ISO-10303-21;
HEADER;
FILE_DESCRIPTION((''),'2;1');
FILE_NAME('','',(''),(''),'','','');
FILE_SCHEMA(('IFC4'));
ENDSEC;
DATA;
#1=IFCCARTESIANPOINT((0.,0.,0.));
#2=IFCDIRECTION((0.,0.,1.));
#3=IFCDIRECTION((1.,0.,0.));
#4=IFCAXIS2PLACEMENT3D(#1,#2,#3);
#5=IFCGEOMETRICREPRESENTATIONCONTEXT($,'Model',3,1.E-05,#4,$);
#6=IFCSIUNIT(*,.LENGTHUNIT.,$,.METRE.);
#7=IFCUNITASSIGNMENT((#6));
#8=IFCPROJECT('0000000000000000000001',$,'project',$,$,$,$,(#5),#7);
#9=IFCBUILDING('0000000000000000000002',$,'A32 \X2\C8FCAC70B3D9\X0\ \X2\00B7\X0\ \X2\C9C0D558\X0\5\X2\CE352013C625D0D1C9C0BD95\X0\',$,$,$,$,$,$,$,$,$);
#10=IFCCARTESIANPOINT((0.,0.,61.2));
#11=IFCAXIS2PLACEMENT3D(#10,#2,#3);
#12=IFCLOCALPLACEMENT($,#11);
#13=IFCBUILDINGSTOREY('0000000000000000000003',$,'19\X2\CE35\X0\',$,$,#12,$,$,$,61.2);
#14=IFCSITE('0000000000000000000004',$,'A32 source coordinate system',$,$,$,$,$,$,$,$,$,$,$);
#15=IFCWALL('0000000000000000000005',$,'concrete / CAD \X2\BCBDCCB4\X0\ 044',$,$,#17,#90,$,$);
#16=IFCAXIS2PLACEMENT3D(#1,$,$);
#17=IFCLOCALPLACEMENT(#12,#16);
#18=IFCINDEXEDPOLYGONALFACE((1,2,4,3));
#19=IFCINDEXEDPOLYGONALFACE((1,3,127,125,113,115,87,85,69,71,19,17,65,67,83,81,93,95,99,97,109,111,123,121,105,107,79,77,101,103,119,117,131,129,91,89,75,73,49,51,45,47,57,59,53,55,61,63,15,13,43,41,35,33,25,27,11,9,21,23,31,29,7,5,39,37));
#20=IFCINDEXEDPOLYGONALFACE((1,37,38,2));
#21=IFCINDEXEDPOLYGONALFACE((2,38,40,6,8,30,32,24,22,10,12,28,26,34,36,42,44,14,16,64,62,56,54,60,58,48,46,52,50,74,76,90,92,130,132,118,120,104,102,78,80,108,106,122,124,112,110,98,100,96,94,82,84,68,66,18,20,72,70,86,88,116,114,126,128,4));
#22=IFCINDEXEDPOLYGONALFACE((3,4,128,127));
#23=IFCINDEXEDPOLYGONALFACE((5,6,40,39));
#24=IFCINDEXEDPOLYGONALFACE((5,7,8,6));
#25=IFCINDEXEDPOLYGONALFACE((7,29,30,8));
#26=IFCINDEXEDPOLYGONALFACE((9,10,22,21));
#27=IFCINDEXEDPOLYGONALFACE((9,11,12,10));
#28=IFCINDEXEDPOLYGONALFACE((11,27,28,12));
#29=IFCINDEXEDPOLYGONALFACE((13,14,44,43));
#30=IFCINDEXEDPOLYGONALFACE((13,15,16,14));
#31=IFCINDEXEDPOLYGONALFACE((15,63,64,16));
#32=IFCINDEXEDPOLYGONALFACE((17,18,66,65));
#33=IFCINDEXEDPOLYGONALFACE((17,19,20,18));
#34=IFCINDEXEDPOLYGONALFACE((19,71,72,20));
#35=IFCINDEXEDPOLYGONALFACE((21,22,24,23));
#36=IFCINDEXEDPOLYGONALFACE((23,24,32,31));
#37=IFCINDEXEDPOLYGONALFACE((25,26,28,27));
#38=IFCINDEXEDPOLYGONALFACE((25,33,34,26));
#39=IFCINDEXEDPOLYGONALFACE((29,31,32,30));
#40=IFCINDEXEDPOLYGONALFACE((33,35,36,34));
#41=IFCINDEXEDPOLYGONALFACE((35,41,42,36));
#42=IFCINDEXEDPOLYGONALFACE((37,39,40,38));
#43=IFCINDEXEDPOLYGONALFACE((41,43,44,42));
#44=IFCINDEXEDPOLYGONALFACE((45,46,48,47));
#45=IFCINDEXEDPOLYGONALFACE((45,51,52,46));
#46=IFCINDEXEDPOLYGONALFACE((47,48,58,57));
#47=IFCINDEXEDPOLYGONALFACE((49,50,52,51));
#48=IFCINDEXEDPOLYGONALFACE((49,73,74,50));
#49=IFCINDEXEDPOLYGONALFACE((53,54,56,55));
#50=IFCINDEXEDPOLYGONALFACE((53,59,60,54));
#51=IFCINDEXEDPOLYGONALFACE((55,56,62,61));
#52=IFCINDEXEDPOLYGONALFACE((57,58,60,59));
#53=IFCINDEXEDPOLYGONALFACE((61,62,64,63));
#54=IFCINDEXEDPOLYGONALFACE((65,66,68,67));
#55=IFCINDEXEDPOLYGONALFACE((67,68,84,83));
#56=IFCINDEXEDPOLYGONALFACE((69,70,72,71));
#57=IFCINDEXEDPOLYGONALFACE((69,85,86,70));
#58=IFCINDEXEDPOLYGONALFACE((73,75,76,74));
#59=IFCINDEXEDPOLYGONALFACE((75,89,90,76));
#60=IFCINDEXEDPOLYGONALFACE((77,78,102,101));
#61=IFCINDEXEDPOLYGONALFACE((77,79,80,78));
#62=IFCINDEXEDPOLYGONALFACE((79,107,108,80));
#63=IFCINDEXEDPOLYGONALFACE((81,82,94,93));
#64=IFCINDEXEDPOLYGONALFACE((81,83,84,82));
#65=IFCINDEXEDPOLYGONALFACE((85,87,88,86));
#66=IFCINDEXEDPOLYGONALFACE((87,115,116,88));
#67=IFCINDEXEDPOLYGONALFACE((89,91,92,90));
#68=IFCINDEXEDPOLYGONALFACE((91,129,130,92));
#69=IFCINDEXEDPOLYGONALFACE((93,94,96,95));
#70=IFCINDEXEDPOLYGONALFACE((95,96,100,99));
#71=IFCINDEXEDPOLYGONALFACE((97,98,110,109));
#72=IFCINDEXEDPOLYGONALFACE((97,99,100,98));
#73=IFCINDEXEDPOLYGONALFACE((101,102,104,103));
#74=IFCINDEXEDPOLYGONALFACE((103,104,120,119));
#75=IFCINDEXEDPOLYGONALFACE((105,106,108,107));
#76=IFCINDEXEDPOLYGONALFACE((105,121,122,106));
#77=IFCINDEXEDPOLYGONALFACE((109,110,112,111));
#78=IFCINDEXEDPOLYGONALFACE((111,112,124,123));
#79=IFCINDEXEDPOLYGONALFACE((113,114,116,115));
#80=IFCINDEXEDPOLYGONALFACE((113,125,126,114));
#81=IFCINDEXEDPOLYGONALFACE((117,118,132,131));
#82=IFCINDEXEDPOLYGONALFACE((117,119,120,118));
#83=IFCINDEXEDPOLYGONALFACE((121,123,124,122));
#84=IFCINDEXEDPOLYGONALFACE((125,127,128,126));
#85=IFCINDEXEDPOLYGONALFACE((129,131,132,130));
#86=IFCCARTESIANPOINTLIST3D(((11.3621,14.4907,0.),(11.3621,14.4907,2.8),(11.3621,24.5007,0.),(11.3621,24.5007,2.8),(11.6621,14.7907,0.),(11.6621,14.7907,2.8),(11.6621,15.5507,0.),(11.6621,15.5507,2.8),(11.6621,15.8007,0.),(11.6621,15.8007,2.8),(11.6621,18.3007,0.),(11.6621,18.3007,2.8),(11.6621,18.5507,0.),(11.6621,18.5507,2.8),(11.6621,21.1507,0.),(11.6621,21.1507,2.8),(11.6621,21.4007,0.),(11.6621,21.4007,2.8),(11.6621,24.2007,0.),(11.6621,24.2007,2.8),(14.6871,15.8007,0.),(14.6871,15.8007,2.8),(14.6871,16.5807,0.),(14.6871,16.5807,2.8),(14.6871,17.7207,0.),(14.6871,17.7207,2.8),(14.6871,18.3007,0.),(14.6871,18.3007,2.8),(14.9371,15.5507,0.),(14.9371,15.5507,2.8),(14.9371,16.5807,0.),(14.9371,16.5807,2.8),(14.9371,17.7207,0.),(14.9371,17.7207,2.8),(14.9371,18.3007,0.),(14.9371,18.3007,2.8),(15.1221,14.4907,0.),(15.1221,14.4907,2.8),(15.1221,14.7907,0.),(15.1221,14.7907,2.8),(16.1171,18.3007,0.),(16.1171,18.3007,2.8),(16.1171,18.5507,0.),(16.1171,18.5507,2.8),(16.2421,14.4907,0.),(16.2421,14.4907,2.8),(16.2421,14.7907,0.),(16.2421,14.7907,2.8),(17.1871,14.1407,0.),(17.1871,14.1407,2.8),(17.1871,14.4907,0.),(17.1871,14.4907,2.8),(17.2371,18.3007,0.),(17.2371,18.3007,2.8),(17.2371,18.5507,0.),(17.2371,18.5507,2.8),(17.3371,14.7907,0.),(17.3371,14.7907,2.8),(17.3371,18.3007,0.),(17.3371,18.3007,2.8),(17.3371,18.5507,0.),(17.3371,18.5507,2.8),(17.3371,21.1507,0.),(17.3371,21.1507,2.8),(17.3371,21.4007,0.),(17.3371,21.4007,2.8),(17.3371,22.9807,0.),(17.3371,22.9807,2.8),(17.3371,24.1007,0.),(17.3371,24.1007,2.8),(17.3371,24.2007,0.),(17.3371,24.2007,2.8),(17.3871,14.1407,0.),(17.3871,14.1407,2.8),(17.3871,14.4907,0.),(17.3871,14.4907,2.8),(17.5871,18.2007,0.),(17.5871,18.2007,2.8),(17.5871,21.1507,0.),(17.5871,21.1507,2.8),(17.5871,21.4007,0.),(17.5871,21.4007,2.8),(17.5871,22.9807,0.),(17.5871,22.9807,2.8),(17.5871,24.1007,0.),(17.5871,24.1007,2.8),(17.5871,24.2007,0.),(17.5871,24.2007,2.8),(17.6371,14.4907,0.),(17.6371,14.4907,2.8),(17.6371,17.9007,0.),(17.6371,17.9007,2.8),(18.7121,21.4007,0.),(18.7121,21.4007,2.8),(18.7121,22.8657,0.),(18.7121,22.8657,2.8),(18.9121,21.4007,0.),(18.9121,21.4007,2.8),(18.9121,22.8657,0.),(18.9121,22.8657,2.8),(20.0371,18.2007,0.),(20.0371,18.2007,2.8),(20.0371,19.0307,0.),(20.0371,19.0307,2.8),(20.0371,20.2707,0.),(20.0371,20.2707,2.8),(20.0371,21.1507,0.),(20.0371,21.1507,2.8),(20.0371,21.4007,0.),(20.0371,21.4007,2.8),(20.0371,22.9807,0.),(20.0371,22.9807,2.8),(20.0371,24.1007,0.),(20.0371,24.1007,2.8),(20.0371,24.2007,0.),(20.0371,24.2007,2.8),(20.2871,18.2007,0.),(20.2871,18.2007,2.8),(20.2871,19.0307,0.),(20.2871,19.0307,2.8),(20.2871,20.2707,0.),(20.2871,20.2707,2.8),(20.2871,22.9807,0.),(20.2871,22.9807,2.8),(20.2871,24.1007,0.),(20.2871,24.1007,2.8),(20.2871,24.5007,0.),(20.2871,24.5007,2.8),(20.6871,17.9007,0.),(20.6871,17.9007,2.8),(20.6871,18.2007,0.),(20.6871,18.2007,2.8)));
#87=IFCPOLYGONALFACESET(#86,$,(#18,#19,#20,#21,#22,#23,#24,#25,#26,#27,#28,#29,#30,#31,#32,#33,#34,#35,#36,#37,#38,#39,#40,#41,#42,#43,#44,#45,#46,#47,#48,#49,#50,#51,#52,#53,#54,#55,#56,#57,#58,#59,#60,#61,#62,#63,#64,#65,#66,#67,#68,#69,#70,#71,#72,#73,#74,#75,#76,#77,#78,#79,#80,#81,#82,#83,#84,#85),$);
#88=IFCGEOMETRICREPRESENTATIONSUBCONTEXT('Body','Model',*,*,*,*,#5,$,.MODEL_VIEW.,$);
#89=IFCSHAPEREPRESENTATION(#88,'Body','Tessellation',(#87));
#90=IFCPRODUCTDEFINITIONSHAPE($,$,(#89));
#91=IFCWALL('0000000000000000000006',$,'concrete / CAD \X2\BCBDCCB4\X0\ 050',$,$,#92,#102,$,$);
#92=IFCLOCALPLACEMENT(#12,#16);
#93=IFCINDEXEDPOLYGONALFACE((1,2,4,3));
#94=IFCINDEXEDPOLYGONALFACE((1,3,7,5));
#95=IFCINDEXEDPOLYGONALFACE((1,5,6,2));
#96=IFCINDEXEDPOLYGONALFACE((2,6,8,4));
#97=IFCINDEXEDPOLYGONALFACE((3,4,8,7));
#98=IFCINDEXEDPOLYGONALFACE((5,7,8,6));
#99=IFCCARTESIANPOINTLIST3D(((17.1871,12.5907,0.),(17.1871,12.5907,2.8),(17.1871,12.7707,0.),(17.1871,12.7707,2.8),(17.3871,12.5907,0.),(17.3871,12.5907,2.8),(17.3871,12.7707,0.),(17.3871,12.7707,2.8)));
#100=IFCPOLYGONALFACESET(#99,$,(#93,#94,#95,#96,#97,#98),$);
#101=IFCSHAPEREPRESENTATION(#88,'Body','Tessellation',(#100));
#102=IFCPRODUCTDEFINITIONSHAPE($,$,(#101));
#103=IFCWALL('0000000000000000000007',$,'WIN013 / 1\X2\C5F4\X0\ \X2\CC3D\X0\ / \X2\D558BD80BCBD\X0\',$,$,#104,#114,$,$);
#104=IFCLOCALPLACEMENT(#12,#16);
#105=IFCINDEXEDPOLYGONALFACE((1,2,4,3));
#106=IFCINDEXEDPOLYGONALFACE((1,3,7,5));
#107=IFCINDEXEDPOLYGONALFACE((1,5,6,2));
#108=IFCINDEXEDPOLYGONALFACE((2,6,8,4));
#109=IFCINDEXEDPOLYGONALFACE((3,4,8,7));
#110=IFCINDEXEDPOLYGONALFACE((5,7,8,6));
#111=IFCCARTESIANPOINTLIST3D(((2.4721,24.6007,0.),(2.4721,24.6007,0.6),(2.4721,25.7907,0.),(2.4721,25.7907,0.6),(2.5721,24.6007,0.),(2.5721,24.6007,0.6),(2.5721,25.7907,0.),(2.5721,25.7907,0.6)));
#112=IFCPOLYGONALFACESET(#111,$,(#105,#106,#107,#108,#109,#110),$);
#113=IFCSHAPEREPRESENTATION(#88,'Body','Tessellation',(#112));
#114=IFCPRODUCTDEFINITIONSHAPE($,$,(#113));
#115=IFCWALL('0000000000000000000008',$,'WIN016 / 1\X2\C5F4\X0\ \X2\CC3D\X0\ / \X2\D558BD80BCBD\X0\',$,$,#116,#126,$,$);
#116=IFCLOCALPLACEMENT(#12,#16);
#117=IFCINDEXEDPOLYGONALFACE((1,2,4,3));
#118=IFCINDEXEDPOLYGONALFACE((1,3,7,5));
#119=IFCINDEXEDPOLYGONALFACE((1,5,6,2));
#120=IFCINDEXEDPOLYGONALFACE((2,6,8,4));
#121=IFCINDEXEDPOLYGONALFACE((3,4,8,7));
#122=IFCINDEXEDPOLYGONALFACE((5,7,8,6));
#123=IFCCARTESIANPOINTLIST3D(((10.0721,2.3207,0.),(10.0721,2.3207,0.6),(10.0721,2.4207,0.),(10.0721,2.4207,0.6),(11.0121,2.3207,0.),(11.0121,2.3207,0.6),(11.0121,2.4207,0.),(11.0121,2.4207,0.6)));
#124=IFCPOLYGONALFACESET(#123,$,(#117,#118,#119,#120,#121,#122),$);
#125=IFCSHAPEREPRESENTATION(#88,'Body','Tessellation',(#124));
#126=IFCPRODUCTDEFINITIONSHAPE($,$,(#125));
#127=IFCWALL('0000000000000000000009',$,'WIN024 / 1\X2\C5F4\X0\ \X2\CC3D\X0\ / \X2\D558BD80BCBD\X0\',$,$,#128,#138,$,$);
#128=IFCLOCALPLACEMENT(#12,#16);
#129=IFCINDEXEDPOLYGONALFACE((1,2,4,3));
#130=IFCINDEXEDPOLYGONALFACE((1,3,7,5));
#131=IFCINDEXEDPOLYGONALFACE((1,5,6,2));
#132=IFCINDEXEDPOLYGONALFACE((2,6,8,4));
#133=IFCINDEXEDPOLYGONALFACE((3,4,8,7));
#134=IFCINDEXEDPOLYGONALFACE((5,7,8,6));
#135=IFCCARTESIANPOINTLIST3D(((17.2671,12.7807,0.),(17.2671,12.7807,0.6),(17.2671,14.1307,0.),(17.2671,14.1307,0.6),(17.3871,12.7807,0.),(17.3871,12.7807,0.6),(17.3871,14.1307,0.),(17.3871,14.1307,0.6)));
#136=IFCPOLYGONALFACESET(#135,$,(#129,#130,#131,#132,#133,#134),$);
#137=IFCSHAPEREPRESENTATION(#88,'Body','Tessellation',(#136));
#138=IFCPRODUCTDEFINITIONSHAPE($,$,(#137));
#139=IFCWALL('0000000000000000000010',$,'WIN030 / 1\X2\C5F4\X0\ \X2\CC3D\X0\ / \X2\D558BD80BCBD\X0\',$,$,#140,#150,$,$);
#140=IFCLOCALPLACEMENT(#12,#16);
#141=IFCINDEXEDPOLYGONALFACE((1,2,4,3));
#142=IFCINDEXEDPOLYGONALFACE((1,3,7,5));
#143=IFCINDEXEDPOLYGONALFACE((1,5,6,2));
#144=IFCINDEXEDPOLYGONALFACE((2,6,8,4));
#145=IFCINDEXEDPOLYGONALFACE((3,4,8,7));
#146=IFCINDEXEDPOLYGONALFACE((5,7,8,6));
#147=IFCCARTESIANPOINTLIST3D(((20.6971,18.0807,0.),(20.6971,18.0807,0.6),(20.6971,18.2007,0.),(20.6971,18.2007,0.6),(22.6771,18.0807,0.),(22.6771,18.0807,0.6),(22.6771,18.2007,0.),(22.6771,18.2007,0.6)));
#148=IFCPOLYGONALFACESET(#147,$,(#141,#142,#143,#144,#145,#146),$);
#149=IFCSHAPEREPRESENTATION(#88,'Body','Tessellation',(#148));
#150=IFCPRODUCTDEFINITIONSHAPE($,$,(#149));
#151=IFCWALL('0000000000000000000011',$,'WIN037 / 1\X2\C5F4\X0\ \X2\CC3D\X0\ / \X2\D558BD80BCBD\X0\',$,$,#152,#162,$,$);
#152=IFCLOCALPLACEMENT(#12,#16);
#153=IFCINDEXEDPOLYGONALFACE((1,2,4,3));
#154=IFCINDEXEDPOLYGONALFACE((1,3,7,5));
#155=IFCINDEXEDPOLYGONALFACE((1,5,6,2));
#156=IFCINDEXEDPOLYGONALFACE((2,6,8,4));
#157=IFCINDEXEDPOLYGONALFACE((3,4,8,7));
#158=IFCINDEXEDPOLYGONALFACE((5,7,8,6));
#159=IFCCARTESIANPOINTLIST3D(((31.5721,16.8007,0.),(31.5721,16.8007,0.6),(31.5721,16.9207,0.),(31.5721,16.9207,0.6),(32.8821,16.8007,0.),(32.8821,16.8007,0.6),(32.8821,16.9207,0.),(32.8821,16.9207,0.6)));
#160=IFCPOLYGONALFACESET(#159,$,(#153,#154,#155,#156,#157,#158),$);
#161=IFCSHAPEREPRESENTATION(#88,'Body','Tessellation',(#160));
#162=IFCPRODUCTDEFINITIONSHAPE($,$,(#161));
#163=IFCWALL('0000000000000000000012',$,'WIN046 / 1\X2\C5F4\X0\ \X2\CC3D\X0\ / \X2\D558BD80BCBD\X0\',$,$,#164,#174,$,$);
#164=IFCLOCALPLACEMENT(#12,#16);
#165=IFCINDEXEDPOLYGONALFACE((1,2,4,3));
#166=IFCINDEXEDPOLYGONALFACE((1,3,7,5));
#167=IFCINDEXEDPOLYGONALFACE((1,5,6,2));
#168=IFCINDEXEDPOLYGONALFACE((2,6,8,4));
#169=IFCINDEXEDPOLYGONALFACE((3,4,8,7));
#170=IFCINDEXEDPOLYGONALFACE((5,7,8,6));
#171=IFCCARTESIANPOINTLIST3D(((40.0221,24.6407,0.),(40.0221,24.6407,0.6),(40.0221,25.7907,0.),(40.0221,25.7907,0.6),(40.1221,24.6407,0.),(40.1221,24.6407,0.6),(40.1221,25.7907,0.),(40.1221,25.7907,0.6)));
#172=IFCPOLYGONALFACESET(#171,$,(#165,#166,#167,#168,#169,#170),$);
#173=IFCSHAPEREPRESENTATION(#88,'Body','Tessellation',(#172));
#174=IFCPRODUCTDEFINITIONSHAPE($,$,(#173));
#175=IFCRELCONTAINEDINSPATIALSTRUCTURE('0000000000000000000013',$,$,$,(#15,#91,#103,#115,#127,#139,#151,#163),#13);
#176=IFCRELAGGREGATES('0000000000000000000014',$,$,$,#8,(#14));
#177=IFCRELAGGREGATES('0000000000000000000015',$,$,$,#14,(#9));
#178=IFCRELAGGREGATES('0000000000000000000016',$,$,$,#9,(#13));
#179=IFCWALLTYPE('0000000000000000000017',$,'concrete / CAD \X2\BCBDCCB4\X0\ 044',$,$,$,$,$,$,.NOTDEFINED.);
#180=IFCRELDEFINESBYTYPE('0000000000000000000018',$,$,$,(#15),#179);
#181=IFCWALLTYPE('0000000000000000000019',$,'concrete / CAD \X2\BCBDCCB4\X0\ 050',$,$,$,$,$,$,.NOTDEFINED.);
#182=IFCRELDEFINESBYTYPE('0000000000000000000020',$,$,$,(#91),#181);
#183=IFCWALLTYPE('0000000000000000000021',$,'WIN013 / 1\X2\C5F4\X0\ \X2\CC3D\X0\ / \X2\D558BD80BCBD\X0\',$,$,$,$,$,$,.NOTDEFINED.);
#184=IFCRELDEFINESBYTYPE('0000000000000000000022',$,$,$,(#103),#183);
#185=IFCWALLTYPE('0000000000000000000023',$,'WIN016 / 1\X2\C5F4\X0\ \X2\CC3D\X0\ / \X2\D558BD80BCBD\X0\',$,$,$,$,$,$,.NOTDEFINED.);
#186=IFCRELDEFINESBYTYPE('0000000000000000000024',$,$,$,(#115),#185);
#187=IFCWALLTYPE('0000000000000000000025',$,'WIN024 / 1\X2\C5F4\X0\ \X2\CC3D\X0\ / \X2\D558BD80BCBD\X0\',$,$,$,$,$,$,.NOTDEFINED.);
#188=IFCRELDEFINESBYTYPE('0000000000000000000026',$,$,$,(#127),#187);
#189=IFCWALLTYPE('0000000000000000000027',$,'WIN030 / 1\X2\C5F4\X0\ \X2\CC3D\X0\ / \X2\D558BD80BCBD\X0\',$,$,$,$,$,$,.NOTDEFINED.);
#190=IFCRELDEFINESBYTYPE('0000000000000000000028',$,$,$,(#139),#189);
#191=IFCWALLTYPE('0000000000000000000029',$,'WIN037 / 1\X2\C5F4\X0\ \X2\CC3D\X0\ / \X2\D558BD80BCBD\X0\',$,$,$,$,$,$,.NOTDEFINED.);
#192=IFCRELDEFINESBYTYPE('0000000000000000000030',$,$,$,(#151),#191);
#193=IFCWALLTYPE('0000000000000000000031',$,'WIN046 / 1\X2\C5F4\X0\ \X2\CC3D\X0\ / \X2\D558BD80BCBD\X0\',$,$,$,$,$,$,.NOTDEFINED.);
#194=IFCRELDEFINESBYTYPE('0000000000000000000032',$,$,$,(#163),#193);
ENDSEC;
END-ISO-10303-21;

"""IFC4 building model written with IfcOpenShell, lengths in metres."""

from ifc_helpers import new_model, si_unit, frame, origin, origin_with_axes, place, context, subcontext, project, spatial, polyline, outline, extrude, source, transform, mapped, type_object, type_shapes, element, save


model = new_model("IFC4")

# Units and contexts
model_context = context("Model", 3, precision=1e-05, world=origin_with_axes())
body_context = subcontext(model_context, "Body", "Model", "MODEL_VIEW")
ifc_project = project(units=[si_unit("LENGTHUNIT", "METRE")], contexts=[model_context])

# Site, building, storey
site = spatial("IfcSite", under=ifc_project, Name="A32 source coordinate system")
building = spatial("IfcBuilding", under=site, Name="A32 주거동 · 지하5층–옥탑지붕")
storey_placement = place(None, frame((0.0, 0.0, 61.2), z_axis=(0.0, 0.0, 1.0), x_axis=(1.0, 0.0, 0.0)))
storey = spatial("IfcBuildingStorey", under=building, at=storey_placement, Name="19층", Elevation=61.2)

# Walls
wall_type_1 = type_object("IfcWallType", Name="concrete / CAD 벽체 044", PredefinedType="NOTDEFINED")
shared_shape_1 = source(origin(), body_context, "Body", "SweptSolid", [
    extrude(outline(polyline([(17.3371, 21.4007), (17.3371, 22.9807), (17.5871, 22.9807), (17.5871, 21.4007), (18.7121, 21.4007), (18.7121, 22.8657), (18.9121, 22.8657), (18.9121, 21.4007), (20.0371, 21.4007), (20.0371, 22.9807), (20.2871, 22.9807), (20.2871, 20.2707), (20.0371, 20.2707), (20.0371, 21.1507), (17.5871, 21.1507), (17.5871, 18.2007), (20.0371, 18.2007), (20.0371, 19.0307), (20.2871, 19.0307), (20.2871, 18.2007), (20.6871, 18.2007), (20.6871, 17.9007), (17.6371, 17.9007), (17.6371, 14.4907), (17.3871, 14.4907), (17.3871, 14.1407), (17.1871, 14.1407), (17.1871, 14.4907), (16.2421, 14.4907), (16.2421, 14.7907), (17.3371, 14.7907), (17.3371, 18.3007), (17.2371, 18.3007), (17.2371, 18.5507), (17.3371, 18.5507), (17.3371, 21.1507), (11.6621, 21.1507), (11.6621, 18.5507), (16.1171, 18.5507), (16.1171, 18.3007), (14.9371, 18.3007), (14.9371, 17.7207), (14.6871, 17.7207), (14.6871, 18.3007), (11.6621, 18.3007), (11.6621, 15.8007), (14.6871, 15.8007), (14.6871, 16.5807), (14.9371, 16.5807), (14.9371, 15.5507), (11.6621, 15.5507), (11.6621, 14.7907), (15.1221, 14.7907), (15.1221, 14.4907), (11.3621, 14.4907), (11.3621, 24.5007), (20.2871, 24.5007), (20.2871, 24.1007), (20.0371, 24.1007), (20.0371, 24.2007), (17.5871, 24.2007), (17.5871, 24.1007), (17.3371, 24.1007), (17.3371, 24.2007), (11.6621, 24.2007), (11.6621, 21.4007), (17.3371, 21.4007)])), origin(), (0.0, 0.0, 1.0), 2.8),
])
type_shapes(wall_type_1, [shared_shape_1])
wall_1_placement = place(storey_placement, origin_with_axes())
element("IfcWall", 1, at=wall_1_placement, inside=storey, type_object=wall_type_1, Name="concrete / CAD 벽체 044", context=body_context, shape_type="MappedRepresentation", body=[
    mapped(shared_shape_1, transform((0.0, 0.0, 0.0), scale=1.0)),
])
wall_type_2 = type_object("IfcWallType", Name="concrete / CAD 벽체 050", PredefinedType="NOTDEFINED")
shared_shape_2 = source(origin(), body_context, "Body", "SweptSolid", [
    extrude(outline(polyline([(17.3871, 12.5907), (17.1871, 12.5907), (17.1871, 12.7707), (17.3871, 12.7707), (17.3871, 12.5907)])), origin(), (0.0, 0.0, 1.0), 2.8),
])
type_shapes(wall_type_2, [shared_shape_2])
wall_2_placement = place(storey_placement, origin_with_axes())
element("IfcWall", 2, at=wall_2_placement, inside=storey, type_object=wall_type_2, Name="concrete / CAD 벽체 050", context=body_context, shape_type="MappedRepresentation", body=[
    mapped(shared_shape_2, transform((0.0, 0.0, 0.0), scale=1.0)),
])
wall_type_3 = type_object("IfcWallType", Name="WIN013 / 1열 창 / 하부벽", PredefinedType="NOTDEFINED")
shared_shape_3 = source(origin(), body_context, "Body", "SweptSolid", [
    extrude(outline(polyline([(2.5721, 25.7907), (2.5721, 24.6007), (2.4721, 24.6007), (2.4721, 25.7907), (2.5721, 25.7907)])), origin(), (0.0, 0.0, 1.0), 0.6),
])
type_shapes(wall_type_3, [shared_shape_3])
wall_3_placement = place(storey_placement, origin_with_axes())
element("IfcWall", 3, at=wall_3_placement, inside=storey, type_object=wall_type_3, Name="WIN013 / 1열 창 / 하부벽", context=body_context, shape_type="MappedRepresentation", body=[
    mapped(shared_shape_3, transform((0.0, 0.0, 0.0), scale=1.0)),
])
wall_type_4 = type_object("IfcWallType", Name="WIN016 / 1열 창 / 하부벽", PredefinedType="NOTDEFINED")
shared_shape_4 = source(origin(), body_context, "Body", "SweptSolid", [
    extrude(outline(polyline([(11.0121, 2.4207), (11.0121, 2.3207), (10.0721, 2.3207), (10.0721, 2.4207), (11.0121, 2.4207)])), origin(), (0.0, 0.0, 1.0), 0.6),
])
type_shapes(wall_type_4, [shared_shape_4])
wall_4_placement = place(storey_placement, origin_with_axes())
element("IfcWall", 4, at=wall_4_placement, inside=storey, type_object=wall_type_4, Name="WIN016 / 1열 창 / 하부벽", context=body_context, shape_type="MappedRepresentation", body=[
    mapped(shared_shape_4, transform((0.0, 0.0, 0.0), scale=1.0)),
])
wall_type_5 = type_object("IfcWallType", Name="WIN024 / 1열 창 / 하부벽", PredefinedType="NOTDEFINED")
shared_shape_5 = source(origin(), body_context, "Body", "SweptSolid", [
    extrude(outline(polyline([(17.3871, 14.1307), (17.3871, 12.7807), (17.2671, 12.7807), (17.2671, 14.1307), (17.3871, 14.1307)])), origin(), (0.0, 0.0, 1.0), 0.6),
])
type_shapes(wall_type_5, [shared_shape_5])
wall_5_placement = place(storey_placement, origin_with_axes())
element("IfcWall", 5, at=wall_5_placement, inside=storey, type_object=wall_type_5, Name="WIN024 / 1열 창 / 하부벽", context=body_context, shape_type="MappedRepresentation", body=[
    mapped(shared_shape_5, transform((0.0, 0.0, 0.0), scale=1.0)),
])
wall_type_6 = type_object("IfcWallType", Name="WIN030 / 1열 창 / 하부벽", PredefinedType="NOTDEFINED")
shared_shape_6 = source(origin(), body_context, "Body", "SweptSolid", [
    extrude(outline(polyline([(22.6771, 18.2007), (22.6771, 18.0807), (20.6971, 18.0807), (20.6971, 18.2007), (22.6771, 18.2007)])), origin(), (0.0, 0.0, 1.0), 0.6),
])
type_shapes(wall_type_6, [shared_shape_6])
wall_6_placement = place(storey_placement, origin_with_axes())
element("IfcWall", 6, at=wall_6_placement, inside=storey, type_object=wall_type_6, Name="WIN030 / 1열 창 / 하부벽", context=body_context, shape_type="MappedRepresentation", body=[
    mapped(shared_shape_6, transform((0.0, 0.0, 0.0), scale=1.0)),
])
wall_type_7 = type_object("IfcWallType", Name="WIN037 / 1열 창 / 하부벽", PredefinedType="NOTDEFINED")
shared_shape_7 = source(origin(), body_context, "Body", "SweptSolid", [
    extrude(outline(polyline([(32.8821, 16.9207), (32.8821, 16.8007), (31.5721, 16.8007), (31.5721, 16.9207), (32.8821, 16.9207)])), origin(), (0.0, 0.0, 1.0), 0.6),
])
type_shapes(wall_type_7, [shared_shape_7])
wall_7_placement = place(storey_placement, origin_with_axes())
element("IfcWall", 7, at=wall_7_placement, inside=storey, type_object=wall_type_7, Name="WIN037 / 1열 창 / 하부벽", context=body_context, shape_type="MappedRepresentation", body=[
    mapped(shared_shape_7, transform((0.0, 0.0, 0.0), scale=1.0)),
])
wall_type_8 = type_object("IfcWallType", Name="WIN046 / 1열 창 / 하부벽", PredefinedType="NOTDEFINED")
shared_shape_8 = source(origin(), body_context, "Body", "SweptSolid", [
    extrude(outline(polyline([(40.1221, 25.7907), (40.1221, 24.6407), (40.0221, 24.6407), (40.0221, 25.7907), (40.1221, 25.7907)])), origin(), (0.0, 0.0, 1.0), 0.6),
])
type_shapes(wall_type_8, [shared_shape_8])
wall_8_placement = place(storey_placement, origin_with_axes())
element("IfcWall", 8, at=wall_8_placement, inside=storey, type_object=wall_type_8, Name="WIN046 / 1열 창 / 하부벽", context=body_context, shape_type="MappedRepresentation", body=[
    mapped(shared_shape_8, transform((0.0, 0.0, 0.0), scale=1.0)),
])

save(model, "model.ifc")
